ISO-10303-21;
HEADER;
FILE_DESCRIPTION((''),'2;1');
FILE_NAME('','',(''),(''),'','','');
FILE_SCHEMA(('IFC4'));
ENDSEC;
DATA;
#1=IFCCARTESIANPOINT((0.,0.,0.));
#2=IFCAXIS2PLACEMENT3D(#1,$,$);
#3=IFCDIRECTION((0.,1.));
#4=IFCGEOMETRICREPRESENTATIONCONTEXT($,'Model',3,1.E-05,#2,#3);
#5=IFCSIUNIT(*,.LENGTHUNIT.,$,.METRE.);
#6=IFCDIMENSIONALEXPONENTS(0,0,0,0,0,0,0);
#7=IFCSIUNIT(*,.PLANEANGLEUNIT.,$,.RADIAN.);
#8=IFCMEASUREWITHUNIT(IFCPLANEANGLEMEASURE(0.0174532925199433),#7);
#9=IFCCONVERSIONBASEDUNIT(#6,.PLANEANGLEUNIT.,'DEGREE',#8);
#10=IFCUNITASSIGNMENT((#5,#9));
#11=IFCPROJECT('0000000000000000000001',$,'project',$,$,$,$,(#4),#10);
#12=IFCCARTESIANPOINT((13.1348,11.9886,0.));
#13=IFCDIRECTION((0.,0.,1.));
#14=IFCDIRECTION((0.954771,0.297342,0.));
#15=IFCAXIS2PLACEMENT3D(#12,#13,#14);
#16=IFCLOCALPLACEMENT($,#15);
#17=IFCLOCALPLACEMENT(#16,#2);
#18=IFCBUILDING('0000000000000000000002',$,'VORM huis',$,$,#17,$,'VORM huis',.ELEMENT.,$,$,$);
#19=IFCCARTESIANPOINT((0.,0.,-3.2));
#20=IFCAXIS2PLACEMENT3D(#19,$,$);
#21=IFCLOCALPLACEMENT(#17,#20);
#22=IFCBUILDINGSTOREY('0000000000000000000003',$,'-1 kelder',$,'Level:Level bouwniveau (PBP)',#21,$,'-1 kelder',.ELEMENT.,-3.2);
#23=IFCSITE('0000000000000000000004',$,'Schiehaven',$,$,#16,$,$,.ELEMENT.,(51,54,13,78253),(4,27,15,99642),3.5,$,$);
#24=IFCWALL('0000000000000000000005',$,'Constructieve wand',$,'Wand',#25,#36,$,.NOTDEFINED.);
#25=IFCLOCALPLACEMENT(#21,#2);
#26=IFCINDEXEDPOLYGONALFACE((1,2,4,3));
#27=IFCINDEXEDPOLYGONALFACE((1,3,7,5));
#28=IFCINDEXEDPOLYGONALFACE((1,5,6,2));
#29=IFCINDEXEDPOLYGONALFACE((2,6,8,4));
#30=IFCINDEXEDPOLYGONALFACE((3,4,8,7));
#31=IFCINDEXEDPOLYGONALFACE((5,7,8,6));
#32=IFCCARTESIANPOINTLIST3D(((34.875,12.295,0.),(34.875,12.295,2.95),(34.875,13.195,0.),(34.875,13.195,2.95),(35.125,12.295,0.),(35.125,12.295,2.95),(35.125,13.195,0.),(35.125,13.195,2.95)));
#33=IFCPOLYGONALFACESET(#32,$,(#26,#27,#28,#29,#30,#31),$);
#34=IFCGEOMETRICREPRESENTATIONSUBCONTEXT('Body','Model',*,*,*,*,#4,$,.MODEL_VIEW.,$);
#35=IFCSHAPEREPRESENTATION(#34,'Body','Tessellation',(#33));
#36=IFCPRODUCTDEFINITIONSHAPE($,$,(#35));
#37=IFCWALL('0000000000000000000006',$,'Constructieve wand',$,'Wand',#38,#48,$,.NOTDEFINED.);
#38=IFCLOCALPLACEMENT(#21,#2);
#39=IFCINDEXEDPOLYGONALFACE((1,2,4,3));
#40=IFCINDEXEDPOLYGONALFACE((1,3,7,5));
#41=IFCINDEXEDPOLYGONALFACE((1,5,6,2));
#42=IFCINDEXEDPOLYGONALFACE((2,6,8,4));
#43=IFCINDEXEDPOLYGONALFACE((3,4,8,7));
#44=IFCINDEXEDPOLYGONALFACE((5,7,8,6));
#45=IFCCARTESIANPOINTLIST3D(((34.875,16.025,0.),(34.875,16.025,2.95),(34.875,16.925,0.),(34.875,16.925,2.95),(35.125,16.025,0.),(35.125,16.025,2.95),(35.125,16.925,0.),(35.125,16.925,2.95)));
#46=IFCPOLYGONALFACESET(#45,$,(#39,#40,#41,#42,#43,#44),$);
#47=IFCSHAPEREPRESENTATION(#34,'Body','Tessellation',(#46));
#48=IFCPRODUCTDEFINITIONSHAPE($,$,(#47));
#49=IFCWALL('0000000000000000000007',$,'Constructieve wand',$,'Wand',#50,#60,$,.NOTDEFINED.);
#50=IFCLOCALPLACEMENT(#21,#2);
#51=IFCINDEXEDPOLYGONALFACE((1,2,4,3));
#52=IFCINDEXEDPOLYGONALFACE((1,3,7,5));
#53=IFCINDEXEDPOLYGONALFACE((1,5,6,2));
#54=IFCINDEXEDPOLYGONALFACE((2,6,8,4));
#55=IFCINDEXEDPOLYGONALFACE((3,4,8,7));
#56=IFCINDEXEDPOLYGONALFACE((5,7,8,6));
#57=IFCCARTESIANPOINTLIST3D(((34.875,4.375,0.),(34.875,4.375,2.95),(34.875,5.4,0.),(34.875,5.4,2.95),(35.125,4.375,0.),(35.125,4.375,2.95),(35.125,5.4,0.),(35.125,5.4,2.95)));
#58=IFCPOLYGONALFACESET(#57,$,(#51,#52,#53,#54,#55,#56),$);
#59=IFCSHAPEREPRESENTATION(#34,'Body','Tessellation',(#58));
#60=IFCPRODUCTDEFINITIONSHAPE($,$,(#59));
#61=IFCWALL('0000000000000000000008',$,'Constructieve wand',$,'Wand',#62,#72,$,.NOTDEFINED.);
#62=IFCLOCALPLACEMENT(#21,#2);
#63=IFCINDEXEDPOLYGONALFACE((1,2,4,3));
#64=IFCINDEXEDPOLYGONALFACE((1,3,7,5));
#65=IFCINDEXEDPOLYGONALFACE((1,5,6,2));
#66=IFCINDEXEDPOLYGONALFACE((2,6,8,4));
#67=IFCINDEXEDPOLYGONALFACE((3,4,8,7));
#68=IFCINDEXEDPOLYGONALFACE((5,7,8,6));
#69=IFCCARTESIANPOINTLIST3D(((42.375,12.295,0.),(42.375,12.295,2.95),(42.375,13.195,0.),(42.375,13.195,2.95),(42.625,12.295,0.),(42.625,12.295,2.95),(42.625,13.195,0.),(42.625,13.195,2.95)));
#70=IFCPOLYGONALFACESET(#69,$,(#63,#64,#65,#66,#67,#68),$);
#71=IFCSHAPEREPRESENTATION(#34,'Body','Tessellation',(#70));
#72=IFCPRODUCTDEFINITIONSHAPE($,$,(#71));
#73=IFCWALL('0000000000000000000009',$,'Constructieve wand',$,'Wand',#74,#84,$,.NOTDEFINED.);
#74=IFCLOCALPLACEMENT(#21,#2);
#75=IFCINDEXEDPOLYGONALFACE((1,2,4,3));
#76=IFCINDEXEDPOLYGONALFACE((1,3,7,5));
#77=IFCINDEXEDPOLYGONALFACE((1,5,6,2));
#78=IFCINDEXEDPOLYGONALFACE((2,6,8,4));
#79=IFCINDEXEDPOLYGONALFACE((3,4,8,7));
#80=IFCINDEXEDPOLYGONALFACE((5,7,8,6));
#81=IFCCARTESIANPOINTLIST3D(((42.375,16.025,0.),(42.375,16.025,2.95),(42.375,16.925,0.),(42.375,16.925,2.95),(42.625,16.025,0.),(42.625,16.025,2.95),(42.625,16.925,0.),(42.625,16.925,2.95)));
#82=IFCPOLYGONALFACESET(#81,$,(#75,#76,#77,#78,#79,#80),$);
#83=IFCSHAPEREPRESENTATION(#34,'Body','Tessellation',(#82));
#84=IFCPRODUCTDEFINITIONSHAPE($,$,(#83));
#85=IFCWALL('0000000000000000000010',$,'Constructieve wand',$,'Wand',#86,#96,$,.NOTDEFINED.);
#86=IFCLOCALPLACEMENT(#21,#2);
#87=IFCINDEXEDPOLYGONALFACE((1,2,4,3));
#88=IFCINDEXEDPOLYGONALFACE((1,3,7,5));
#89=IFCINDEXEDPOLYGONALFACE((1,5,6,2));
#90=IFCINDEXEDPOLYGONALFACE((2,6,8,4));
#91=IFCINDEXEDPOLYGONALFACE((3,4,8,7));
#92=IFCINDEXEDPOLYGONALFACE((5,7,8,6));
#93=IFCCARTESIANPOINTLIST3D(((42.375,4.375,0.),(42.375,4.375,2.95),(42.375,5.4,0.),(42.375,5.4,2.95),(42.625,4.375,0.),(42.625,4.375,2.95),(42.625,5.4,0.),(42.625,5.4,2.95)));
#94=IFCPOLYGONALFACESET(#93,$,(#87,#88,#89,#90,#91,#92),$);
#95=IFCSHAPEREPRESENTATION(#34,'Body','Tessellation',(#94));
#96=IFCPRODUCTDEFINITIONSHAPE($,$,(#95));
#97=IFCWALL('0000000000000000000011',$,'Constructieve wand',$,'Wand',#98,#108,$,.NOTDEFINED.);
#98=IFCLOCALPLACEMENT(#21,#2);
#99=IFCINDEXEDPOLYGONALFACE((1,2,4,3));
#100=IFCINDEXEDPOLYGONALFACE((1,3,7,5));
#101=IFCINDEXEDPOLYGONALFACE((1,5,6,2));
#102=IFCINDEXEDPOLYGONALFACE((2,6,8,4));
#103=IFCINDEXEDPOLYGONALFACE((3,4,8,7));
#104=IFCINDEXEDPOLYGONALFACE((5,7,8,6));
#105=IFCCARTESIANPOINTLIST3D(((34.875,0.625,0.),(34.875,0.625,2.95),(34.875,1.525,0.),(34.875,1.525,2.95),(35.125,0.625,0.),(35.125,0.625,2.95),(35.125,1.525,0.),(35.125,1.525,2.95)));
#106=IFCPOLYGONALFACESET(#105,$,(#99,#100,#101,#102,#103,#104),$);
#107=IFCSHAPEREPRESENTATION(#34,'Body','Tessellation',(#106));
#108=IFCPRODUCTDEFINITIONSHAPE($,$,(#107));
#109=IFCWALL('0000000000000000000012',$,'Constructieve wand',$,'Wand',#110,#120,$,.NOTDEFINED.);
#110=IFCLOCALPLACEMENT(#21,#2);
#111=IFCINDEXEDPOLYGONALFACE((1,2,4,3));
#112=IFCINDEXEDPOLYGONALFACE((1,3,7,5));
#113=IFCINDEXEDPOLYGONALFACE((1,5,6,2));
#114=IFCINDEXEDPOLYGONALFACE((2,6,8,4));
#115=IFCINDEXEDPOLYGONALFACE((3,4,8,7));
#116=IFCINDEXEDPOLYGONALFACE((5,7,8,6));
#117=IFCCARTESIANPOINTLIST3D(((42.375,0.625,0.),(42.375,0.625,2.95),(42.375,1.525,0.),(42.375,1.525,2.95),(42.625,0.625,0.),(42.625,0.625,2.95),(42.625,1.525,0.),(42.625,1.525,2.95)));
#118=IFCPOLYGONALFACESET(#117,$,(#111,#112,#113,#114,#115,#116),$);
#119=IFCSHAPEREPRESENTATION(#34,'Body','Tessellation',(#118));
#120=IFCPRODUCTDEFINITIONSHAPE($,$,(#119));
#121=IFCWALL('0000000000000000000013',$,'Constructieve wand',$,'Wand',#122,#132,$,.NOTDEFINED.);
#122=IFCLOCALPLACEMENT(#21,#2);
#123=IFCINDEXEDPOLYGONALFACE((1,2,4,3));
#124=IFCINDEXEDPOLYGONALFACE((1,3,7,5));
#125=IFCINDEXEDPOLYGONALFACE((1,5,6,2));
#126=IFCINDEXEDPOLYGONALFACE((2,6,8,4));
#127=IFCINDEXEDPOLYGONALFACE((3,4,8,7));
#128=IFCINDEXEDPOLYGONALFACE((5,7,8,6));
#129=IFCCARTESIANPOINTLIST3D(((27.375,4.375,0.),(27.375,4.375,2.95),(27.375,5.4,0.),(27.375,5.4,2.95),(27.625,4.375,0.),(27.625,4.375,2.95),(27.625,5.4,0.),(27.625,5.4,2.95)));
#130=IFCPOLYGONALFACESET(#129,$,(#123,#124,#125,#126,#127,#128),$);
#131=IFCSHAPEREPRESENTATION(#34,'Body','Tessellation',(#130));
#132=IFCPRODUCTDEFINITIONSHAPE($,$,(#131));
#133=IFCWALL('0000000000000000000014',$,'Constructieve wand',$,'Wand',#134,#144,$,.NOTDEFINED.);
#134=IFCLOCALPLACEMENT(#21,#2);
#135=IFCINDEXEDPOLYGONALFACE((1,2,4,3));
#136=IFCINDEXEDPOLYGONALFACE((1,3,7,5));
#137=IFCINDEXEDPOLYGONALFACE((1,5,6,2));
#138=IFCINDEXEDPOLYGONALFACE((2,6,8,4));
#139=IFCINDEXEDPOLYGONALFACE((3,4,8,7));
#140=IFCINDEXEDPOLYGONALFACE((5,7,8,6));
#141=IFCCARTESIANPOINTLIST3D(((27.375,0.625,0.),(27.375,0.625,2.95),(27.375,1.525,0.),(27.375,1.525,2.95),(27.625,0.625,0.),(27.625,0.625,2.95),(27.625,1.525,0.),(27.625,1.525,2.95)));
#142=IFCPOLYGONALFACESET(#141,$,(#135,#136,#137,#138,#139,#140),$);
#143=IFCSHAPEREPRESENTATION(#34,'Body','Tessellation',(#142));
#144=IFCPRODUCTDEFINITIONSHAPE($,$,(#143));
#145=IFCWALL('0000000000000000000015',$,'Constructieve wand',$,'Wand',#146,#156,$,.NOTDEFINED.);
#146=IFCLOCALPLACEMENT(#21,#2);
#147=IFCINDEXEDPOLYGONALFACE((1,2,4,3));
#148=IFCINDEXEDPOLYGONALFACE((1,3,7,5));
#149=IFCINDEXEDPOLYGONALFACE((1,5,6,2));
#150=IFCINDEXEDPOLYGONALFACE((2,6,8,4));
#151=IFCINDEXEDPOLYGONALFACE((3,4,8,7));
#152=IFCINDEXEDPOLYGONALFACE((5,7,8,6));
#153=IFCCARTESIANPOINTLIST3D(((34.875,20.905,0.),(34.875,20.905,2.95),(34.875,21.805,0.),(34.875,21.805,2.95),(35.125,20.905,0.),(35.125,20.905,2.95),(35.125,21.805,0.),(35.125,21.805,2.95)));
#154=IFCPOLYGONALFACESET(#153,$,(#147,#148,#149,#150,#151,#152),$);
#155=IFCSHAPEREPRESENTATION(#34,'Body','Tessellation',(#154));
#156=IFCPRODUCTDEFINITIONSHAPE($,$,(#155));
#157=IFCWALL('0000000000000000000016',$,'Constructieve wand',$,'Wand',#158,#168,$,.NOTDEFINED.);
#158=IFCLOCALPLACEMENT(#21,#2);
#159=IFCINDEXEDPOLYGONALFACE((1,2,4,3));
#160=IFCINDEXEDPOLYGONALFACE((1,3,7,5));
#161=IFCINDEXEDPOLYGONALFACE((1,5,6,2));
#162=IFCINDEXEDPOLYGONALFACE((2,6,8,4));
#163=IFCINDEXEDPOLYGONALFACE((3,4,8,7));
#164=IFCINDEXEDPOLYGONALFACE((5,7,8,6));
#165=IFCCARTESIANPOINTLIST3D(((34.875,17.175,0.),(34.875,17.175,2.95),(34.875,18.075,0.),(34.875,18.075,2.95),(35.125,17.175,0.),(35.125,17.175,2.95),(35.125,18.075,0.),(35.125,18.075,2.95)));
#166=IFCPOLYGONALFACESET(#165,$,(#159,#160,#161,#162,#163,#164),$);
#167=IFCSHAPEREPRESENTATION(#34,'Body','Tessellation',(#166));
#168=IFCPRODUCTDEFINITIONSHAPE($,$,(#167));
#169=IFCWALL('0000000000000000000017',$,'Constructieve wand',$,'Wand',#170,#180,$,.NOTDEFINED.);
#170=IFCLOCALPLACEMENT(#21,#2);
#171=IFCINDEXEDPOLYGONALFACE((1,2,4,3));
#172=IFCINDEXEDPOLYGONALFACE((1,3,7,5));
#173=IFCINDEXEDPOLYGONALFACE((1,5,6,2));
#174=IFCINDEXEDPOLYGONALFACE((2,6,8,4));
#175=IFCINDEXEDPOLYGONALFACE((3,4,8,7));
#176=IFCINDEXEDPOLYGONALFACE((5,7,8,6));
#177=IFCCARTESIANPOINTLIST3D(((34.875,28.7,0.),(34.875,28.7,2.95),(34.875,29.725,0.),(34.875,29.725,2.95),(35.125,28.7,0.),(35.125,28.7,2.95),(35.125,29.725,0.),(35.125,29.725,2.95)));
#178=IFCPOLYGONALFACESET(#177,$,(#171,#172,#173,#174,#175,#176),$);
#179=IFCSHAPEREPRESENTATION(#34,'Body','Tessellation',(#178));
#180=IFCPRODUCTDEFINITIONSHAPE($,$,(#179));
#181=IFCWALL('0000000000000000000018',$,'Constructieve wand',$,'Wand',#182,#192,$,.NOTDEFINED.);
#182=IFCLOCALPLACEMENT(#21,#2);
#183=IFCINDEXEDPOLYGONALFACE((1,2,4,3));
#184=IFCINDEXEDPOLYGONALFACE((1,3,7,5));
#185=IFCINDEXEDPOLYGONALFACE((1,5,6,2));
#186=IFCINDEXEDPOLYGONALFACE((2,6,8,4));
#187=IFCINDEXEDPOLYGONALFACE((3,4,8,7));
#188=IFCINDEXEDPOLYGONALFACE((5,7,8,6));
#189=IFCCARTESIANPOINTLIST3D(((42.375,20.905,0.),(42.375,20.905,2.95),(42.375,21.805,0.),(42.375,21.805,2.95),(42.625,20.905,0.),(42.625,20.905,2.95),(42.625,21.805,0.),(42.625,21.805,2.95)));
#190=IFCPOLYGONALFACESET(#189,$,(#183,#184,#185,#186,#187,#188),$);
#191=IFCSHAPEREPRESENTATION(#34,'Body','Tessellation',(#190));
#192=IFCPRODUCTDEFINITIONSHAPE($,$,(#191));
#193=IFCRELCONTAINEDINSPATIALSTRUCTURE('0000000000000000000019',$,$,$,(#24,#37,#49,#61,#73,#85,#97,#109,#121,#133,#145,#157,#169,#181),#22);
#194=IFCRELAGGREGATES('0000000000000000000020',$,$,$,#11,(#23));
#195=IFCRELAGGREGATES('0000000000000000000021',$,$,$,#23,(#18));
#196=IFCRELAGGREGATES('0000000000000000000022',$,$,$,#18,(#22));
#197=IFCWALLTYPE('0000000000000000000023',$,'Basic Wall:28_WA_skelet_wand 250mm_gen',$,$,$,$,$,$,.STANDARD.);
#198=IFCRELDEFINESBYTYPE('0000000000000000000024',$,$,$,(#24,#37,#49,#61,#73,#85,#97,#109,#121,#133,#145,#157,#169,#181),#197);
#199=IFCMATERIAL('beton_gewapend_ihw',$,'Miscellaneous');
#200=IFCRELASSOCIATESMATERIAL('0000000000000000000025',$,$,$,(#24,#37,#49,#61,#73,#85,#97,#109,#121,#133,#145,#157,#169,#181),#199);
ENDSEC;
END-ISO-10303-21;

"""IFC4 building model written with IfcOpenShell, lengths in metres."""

from ifc_helpers import new_model, entity, si_unit, converted_unit, direction, frame, origin, place, context, subcontext, project, spatial, indexed_curve, outline, extrude, material, type_object, element, save


model = new_model("IFC4")

# Units and contexts
model_context = context("Model", 3, precision=1e-05, world=origin(), true_north=direction((0.0, 1.0)))
body_context = subcontext(model_context, "Body", "Model", "MODEL_VIEW")
ifc_project = project(units=[si_unit("LENGTHUNIT", "METRE"), converted_unit("PLANEANGLEUNIT", "DEGREE", entity("IfcPlaneAngleMeasure", 0.0174532925199433), si_unit("PLANEANGLEUNIT", "RADIAN"), dimensions=[0, 0, 0, 0, 0, 0, 0])], contexts=[model_context])

# Site, building, storey
site_placement = place(None, frame((13.1348, 11.9886, 0.0), z_axis=(0.0, 0.0, 1.0), x_axis=(0.954771, 0.297342, 0.0)))
site = spatial("IfcSite", under=ifc_project, at=site_placement, Name="Schiehaven", CompositionType="ELEMENT", RefLatitude=(51, 54, 13, 78253), RefLongitude=(4, 27, 15, 99642), RefElevation=3.5)
building_placement = place(site_placement, origin())
building = spatial("IfcBuilding", under=site, at=building_placement, Name="VORM huis", LongName="VORM huis", CompositionType="ELEMENT")
storey_placement = place(building_placement, frame((0.0, 0.0, -3.2)))
storey = spatial("IfcBuildingStorey", under=building, at=storey_placement, Name="-1 kelder", ObjectType="Level:Level bouwniveau (PBP)", LongName="-1 kelder", CompositionType="ELEMENT", Elevation=-3.2)

# Walls
ifc_material_1 = material(Name="beton_gewapend_ihw", Category="Miscellaneous")
wall_type_1 = type_object("IfcWallType", Name="Basic Wall:28_WA_skelet_wand 250mm_gen", PredefinedType="STANDARD")
wall_1_placement = place(storey_placement, frame((35.0, 12.295, 0.0), z_axis=(0.0, 0.0, 1.0), x_axis=(0.0, 1.0, 0.0)))
element("IfcWall", 1, at=wall_1_placement, inside=storey, type_object=wall_type_1, material=ifc_material_1, Name="Constructieve wand", ObjectType="Wand", PredefinedType="NOTDEFINED", context=body_context, shape_type="SweptSolid", body=[
    extrude(outline(indexed_curve([(0.9, 0.125), (0.0, 0.125), (0.0, -0.125), (0.9, -0.125), (0.9, 0.125)], self_intersect=False)), origin(), (0.0, 0.0, 1.0), 2.95),
])
wall_2_placement = place(storey_placement, frame((35.0, 16.025, 0.0), z_axis=(0.0, 0.0, 1.0), x_axis=(0.0, 1.0, 0.0)))
element("IfcWall", 2, at=wall_2_placement, inside=storey, type_object=wall_type_1, material=ifc_material_1, Name="Constructieve wand", ObjectType="Wand", PredefinedType="NOTDEFINED", context=body_context, shape_type="SweptSolid", body=[
    extrude(outline(indexed_curve([(0.9, 0.125), (0.0, 0.125), (0.0, -0.125), (0.9, -0.125), (0.9, 0.125)], self_intersect=False)), origin(), (0.0, 0.0, 1.0), 2.95),
])
wall_3_placement = place(storey_placement, frame((35.0, 4.375, 0.0), z_axis=(0.0, 0.0, 1.0), x_axis=(0.0, 1.0, 0.0)))
element("IfcWall", 3, at=wall_3_placement, inside=storey, type_object=wall_type_1, material=ifc_material_1, Name="Constructieve wand", ObjectType="Wand", PredefinedType="NOTDEFINED", context=body_context, shape_type="SweptSolid", body=[
    extrude(outline(indexed_curve([(1.025, 0.125), (0.0, 0.125), (0.0, -0.125), (1.025, -0.125), (1.025, 0.125)], self_intersect=False)), origin(), (0.0, 0.0, 1.0), 2.95),
])
wall_4_placement = place(storey_placement, frame((42.5, 12.295, 0.0), z_axis=(0.0, 0.0, 1.0), x_axis=(0.0, 1.0, 0.0)))
element("IfcWall", 4, at=wall_4_placement, inside=storey, type_object=wall_type_1, material=ifc_material_1, Name="Constructieve wand", ObjectType="Wand", PredefinedType="NOTDEFINED", context=body_context, shape_type="SweptSolid", body=[
    extrude(outline(indexed_curve([(0.9, 0.125), (0.0, 0.125), (0.0, -0.125), (0.9, -0.125), (0.9, 0.125)], self_intersect=False)), origin(), (0.0, 0.0, 1.0), 2.95),
])
wall_5_placement = place(storey_placement, frame((42.5, 16.025, 0.0), z_axis=(0.0, 0.0, 1.0), x_axis=(0.0, 1.0, 0.0)))
element("IfcWall", 5, at=wall_5_placement, inside=storey, type_object=wall_type_1, material=ifc_material_1, Name="Constructieve wand", ObjectType="Wand", PredefinedType="NOTDEFINED", context=body_context, shape_type="SweptSolid", body=[
    extrude(outline(indexed_curve([(0.9, 0.125), (0.0, 0.125), (0.0, -0.125), (0.9, -0.125), (0.9, 0.125)], self_intersect=False)), origin(), (0.0, 0.0, 1.0), 2.95),
])
wall_6_placement = place(storey_placement, frame((42.5, 4.375, 0.0), z_axis=(0.0, 0.0, 1.0), x_axis=(0.0, 1.0, 0.0)))
element("IfcWall", 6, at=wall_6_placement, inside=storey, type_object=wall_type_1, material=ifc_material_1, Name="Constructieve wand", ObjectType="Wand", PredefinedType="NOTDEFINED", context=body_context, shape_type="SweptSolid", body=[
    extrude(outline(indexed_curve([(1.025, 0.125), (0.0, 0.125), (0.0, -0.125), (1.025, -0.125), (1.025, 0.125)], self_intersect=False)), origin(), (0.0, 0.0, 1.0), 2.95),
])
wall_7_placement = place(storey_placement, frame((35.0, 1.525, 0.0), z_axis=(0.0, 0.0, 1.0), x_axis=(0.0, -1.0, 0.0)))
element("IfcWall", 7, at=wall_7_placement, inside=storey, type_object=wall_type_1, material=ifc_material_1, Name="Constructieve wand", ObjectType="Wand", PredefinedType="NOTDEFINED", context=body_context, shape_type="SweptSolid", body=[
    extrude(outline(indexed_curve([(0.9, 0.125), (0.0, 0.125), (0.0, -0.125), (0.9, -0.125), (0.9, 0.125)], self_intersect=False)), origin(), (0.0, 0.0, 1.0), 2.95),
])
wall_8_placement = place(storey_placement, frame((42.5, 1.525, 0.0), z_axis=(0.0, 0.0, 1.0), x_axis=(0.0, -1.0, 0.0)))
element("IfcWall", 8, at=wall_8_placement, inside=storey, type_object=wall_type_1, material=ifc_material_1, Name="Constructieve wand", ObjectType="Wand", PredefinedType="NOTDEFINED", context=body_context, shape_type="SweptSolid", body=[
    extrude(outline(indexed_curve([(0.9, 0.125), (0.0, 0.125), (0.0, -0.125), (0.9, -0.125), (0.9, 0.125)], self_intersect=False)), origin(), (0.0, 0.0, 1.0), 2.95),
])
wall_9_placement = place(storey_placement, frame((27.5, 4.375, 0.0), z_axis=(0.0, 0.0, 1.0), x_axis=(0.0, 1.0, 0.0)))
element("IfcWall", 9, at=wall_9_placement, inside=storey, type_object=wall_type_1, material=ifc_material_1, Name="Constructieve wand", ObjectType="Wand", PredefinedType="NOTDEFINED", context=body_context, shape_type="SweptSolid", body=[
    extrude(outline(indexed_curve([(1.025, 0.125), (0.0, 0.125), (0.0, -0.125), (1.025, -0.125), (1.025, 0.125)], self_intersect=False)), origin(), (0.0, 0.0, 1.0), 2.95),
])
wall_10_placement = place(storey_placement, frame((27.5, 1.525, 0.0), z_axis=(0.0, 0.0, 1.0), x_axis=(0.0, -1.0, 0.0)))
element("IfcWall", 10, at=wall_10_placement, inside=storey, type_object=wall_type_1, material=ifc_material_1, Name="Constructieve wand", ObjectType="Wand", PredefinedType="NOTDEFINED", context=body_context, shape_type="SweptSolid", body=[
    extrude(outline(indexed_curve([(0.9, 0.125), (0.0, 0.125), (0.0, -0.125), (0.9, -0.125), (0.9, 0.125)], self_intersect=False)), origin(), (0.0, 0.0, 1.0), 2.95),
])
wall_11_placement = place(storey_placement, frame((35.0, 21.805, 0.0), z_axis=(0.0, 0.0, 1.0), x_axis=(0.0, -1.0, 0.0)))
element("IfcWall", 11, at=wall_11_placement, inside=storey, type_object=wall_type_1, material=ifc_material_1, Name="Constructieve wand", ObjectType="Wand", PredefinedType="NOTDEFINED", context=body_context, shape_type="SweptSolid", body=[
    extrude(outline(indexed_curve([(0.9, 0.125), (0.0, 0.125), (0.0, -0.125), (0.9, -0.125), (0.9, 0.125)], self_intersect=False)), origin(), (0.0, 0.0, 1.0), 2.95),
])
wall_12_placement = place(storey_placement, frame((35.0, 18.075, 0.0), z_axis=(0.0, 0.0, 1.0), x_axis=(0.0, -1.0, 0.0)))
element("IfcWall", 12, at=wall_12_placement, inside=storey, type_object=wall_type_1, material=ifc_material_1, Name="Constructieve wand", ObjectType="Wand", PredefinedType="NOTDEFINED", context=body_context, shape_type="SweptSolid", body=[
    extrude(outline(indexed_curve([(0.9, 0.125), (0.0, 0.125), (0.0, -0.125), (0.9, -0.125), (0.9, 0.125)], self_intersect=False)), origin(), (0.0, 0.0, 1.0), 2.95),
])
wall_13_placement = place(storey_placement, frame((35.0, 29.725, 0.0), z_axis=(0.0, 0.0, 1.0), x_axis=(0.0, -1.0, 0.0)))
element("IfcWall", 13, at=wall_13_placement, inside=storey, type_object=wall_type_1, material=ifc_material_1, Name="Constructieve wand", ObjectType="Wand", PredefinedType="NOTDEFINED", context=body_context, shape_type="SweptSolid", body=[
    extrude(outline(indexed_curve([(1.025, 0.125), (0.0, 0.125), (0.0, -0.125), (1.025, -0.125), (1.025, 0.125)], self_intersect=False)), origin(), (0.0, 0.0, 1.0), 2.95),
])
wall_14_placement = place(storey_placement, frame((42.5, 21.805, 0.0), z_axis=(0.0, 0.0, 1.0), x_axis=(0.0, -1.0, 0.0)))
element("IfcWall", 14, at=wall_14_placement, inside=storey, type_object=wall_type_1, material=ifc_material_1, Name="Constructieve wand", ObjectType="Wand", PredefinedType="NOTDEFINED", context=body_context, shape_type="SweptSolid", body=[
    extrude(outline(indexed_curve([(0.9, 0.125), (0.0, 0.125), (0.0, -0.125), (0.9, -0.125), (0.9, 0.125)], self_intersect=False)), origin(), (0.0, 0.0, 1.0), 2.95),
])

save(model, "model.ifc")
